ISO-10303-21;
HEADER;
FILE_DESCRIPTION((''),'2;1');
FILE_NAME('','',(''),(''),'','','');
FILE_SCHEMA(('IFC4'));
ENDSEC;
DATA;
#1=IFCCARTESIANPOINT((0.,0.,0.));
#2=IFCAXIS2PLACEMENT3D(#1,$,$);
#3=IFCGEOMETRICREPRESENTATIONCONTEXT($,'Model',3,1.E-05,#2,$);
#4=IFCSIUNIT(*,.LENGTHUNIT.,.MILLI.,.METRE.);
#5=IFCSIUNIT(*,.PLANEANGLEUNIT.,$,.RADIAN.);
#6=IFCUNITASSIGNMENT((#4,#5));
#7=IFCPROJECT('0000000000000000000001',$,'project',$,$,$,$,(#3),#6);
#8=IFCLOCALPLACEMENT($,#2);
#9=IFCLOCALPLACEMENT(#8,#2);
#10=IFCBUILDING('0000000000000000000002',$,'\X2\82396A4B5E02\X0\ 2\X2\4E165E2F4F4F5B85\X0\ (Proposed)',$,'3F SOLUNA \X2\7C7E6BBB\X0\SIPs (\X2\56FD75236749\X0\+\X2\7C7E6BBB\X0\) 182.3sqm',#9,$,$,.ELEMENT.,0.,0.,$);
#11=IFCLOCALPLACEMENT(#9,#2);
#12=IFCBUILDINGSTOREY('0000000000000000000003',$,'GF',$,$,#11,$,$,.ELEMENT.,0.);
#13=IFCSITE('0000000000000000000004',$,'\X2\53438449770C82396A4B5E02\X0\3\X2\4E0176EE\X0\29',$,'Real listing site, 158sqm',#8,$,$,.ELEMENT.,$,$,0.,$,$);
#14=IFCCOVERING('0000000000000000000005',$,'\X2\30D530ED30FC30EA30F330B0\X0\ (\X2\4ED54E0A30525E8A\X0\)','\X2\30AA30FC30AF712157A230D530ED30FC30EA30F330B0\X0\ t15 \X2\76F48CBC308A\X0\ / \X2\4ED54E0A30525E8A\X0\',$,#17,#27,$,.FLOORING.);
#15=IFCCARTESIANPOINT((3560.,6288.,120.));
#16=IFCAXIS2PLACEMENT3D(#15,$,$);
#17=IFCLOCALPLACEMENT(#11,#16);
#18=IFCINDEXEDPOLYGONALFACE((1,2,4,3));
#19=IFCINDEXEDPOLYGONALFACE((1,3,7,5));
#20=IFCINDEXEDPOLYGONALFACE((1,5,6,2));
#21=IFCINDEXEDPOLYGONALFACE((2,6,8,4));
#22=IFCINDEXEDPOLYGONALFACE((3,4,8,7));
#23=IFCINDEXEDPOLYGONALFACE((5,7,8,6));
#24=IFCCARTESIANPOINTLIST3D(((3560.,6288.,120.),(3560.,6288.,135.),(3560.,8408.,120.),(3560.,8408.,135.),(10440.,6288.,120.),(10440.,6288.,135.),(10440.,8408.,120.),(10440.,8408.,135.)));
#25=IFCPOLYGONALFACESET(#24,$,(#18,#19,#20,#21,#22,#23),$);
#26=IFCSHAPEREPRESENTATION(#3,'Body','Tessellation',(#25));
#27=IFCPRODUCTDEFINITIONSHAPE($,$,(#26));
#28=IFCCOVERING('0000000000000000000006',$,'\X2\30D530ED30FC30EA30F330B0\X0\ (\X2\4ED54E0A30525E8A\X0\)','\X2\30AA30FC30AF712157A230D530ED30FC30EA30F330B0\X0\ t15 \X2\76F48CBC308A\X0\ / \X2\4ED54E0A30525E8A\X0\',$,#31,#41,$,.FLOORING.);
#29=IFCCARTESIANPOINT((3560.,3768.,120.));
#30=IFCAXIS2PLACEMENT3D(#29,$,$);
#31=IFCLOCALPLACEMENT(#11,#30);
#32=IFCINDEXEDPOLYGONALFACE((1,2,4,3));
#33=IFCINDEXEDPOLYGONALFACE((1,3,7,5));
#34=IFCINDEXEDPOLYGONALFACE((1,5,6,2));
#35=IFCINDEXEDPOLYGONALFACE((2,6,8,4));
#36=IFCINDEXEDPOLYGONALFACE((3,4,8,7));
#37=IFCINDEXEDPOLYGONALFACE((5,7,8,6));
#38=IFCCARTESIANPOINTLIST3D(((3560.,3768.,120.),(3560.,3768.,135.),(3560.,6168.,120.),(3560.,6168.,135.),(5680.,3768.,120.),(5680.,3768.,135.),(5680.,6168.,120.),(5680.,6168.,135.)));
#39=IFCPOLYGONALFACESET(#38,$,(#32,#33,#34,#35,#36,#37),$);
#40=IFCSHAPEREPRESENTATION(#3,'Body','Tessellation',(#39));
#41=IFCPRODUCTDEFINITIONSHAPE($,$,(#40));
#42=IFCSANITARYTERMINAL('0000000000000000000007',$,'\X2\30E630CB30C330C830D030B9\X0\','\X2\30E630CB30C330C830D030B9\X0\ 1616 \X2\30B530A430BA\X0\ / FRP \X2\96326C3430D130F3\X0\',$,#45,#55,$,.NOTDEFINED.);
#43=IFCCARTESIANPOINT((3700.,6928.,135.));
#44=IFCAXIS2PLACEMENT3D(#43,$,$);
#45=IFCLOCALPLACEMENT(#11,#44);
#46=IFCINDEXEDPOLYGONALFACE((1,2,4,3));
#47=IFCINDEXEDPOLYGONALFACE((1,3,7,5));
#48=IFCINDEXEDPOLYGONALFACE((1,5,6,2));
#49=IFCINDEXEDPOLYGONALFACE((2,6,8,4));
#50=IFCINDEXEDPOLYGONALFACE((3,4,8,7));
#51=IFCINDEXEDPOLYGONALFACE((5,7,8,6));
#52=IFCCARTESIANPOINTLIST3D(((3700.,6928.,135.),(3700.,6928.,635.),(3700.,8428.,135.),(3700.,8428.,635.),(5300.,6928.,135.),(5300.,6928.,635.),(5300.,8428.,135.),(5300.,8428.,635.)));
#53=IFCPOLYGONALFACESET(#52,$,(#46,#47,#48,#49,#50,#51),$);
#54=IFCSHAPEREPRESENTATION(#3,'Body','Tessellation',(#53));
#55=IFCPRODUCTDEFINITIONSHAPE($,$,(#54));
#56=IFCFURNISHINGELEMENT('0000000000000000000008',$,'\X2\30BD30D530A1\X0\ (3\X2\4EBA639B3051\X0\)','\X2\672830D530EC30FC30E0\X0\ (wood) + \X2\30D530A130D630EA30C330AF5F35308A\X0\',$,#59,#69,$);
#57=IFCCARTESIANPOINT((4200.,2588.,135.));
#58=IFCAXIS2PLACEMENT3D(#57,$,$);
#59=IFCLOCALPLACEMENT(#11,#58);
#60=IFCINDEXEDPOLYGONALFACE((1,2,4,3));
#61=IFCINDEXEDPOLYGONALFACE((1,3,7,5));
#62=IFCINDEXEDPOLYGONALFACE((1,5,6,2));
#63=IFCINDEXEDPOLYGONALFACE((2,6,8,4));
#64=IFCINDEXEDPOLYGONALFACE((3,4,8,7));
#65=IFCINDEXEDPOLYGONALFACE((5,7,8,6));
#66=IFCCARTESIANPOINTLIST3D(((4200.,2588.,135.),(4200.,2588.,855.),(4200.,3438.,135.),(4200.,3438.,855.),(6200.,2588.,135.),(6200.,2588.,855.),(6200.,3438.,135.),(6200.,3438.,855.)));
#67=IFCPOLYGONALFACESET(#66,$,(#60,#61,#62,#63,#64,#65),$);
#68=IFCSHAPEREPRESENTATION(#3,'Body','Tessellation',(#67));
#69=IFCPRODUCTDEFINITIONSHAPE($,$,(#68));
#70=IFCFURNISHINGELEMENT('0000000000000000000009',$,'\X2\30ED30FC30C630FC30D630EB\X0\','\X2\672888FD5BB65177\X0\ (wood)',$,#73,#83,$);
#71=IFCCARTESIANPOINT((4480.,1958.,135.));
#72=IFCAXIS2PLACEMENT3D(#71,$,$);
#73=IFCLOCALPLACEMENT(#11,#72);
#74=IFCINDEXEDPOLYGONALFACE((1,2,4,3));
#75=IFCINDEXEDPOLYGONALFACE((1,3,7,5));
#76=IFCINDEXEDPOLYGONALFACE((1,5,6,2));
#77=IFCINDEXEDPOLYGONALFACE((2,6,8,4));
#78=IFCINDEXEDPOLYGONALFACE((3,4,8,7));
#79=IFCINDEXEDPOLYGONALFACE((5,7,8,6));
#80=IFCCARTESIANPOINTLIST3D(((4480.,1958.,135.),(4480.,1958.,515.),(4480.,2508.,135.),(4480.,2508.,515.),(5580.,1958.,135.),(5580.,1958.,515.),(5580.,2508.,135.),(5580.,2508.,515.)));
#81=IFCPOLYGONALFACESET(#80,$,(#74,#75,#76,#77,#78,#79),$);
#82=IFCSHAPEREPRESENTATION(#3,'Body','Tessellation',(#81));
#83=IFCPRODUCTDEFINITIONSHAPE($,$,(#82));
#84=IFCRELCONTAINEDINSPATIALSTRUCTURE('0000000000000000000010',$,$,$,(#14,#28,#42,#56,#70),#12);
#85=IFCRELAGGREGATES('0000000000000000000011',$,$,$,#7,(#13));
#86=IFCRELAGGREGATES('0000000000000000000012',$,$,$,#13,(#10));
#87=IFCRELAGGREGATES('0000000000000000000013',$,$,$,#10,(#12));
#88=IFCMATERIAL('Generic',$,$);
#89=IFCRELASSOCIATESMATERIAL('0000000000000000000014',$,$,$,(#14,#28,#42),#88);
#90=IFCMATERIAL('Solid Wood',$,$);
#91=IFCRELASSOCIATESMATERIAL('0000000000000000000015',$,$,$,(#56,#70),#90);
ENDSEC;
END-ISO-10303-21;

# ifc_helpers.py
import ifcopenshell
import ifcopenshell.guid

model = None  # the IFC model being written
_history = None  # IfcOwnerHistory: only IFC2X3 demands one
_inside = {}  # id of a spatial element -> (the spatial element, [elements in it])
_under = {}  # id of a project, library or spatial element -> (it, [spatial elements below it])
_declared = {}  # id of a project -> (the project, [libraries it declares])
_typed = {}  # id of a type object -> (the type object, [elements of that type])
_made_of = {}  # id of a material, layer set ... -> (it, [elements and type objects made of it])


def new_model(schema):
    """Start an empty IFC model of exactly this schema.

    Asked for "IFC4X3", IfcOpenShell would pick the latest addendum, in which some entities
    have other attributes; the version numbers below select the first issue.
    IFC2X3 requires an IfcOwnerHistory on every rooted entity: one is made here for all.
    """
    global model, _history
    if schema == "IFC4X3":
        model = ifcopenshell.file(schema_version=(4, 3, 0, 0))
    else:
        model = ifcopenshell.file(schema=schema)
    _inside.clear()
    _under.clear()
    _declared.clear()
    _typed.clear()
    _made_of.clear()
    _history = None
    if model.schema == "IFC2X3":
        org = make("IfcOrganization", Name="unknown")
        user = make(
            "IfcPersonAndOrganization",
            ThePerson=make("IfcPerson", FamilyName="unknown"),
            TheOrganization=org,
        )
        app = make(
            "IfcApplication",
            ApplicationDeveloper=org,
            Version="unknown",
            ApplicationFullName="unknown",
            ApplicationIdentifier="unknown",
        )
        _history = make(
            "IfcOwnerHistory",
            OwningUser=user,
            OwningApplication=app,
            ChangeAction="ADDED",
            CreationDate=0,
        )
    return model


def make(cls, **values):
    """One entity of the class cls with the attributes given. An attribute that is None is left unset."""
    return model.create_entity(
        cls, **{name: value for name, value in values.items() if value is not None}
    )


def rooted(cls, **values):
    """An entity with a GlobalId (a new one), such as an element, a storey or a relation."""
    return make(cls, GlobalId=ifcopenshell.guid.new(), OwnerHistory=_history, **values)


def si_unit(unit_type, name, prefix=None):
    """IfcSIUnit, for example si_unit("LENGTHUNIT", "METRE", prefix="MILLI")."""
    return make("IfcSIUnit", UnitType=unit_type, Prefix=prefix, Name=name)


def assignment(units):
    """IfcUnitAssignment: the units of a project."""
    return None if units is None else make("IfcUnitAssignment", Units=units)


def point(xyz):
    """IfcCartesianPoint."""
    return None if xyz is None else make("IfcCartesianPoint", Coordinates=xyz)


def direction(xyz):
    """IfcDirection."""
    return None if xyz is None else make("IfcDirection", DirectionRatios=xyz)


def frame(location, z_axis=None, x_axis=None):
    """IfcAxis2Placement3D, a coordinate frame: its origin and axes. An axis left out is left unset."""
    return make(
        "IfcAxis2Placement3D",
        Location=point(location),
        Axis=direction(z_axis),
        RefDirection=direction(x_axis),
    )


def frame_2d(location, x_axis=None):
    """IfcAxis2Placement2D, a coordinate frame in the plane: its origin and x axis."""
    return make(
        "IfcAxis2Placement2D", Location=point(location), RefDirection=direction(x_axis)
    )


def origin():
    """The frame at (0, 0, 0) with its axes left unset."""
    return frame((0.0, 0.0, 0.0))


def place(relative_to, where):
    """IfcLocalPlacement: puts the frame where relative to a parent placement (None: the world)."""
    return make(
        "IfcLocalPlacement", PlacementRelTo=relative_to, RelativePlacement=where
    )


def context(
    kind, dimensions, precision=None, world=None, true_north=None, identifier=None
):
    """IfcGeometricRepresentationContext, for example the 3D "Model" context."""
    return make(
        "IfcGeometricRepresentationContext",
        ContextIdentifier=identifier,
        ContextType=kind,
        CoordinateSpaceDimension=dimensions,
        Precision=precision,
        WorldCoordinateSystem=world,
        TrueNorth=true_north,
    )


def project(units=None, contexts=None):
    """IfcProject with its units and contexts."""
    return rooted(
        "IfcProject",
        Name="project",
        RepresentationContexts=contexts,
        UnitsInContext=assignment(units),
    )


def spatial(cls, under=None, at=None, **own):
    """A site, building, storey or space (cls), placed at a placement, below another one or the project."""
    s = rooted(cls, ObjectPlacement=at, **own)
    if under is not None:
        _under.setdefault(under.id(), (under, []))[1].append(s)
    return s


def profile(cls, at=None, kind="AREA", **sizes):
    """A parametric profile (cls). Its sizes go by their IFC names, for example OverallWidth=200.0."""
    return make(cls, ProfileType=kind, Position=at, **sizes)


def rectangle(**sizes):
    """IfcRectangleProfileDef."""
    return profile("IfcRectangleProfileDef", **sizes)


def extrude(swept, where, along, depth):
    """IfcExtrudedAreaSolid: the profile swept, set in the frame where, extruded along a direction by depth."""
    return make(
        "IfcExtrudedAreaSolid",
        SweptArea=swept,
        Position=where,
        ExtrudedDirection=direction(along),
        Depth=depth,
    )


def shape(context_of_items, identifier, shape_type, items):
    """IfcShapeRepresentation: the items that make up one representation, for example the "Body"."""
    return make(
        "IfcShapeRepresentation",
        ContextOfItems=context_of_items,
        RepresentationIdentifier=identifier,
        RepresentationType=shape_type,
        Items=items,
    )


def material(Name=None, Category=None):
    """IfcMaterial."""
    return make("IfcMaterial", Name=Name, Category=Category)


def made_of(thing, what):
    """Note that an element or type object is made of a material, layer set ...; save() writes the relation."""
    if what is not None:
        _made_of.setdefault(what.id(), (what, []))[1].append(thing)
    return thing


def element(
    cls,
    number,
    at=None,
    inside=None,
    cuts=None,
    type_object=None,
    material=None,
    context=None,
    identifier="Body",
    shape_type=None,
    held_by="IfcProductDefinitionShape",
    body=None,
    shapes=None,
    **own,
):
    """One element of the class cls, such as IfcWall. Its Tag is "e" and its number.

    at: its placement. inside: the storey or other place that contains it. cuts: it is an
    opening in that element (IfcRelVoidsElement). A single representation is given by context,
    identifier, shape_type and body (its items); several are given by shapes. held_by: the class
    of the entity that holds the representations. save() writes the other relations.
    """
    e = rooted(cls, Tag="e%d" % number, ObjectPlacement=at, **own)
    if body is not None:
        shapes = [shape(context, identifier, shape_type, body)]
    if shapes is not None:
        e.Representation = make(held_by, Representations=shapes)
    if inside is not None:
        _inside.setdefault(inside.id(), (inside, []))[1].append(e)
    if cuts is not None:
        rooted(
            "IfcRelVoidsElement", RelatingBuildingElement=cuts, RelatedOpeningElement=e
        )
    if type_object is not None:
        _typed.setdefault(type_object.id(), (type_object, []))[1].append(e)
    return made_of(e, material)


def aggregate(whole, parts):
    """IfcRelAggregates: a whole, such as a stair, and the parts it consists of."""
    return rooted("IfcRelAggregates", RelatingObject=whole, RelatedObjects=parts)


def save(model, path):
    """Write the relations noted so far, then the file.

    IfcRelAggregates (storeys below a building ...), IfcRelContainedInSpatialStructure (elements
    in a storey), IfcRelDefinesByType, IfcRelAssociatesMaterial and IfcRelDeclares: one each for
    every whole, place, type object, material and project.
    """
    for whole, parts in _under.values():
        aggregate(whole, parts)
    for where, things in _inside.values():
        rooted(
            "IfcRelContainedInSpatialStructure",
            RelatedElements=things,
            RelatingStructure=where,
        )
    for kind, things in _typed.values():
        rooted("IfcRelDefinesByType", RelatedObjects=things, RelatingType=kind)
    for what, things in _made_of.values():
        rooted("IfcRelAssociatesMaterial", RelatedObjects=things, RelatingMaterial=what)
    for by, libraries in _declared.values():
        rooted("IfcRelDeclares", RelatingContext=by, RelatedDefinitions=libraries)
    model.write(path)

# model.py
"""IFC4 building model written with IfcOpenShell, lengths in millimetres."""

from ifc_helpers import new_model, si_unit, frame, frame_2d, origin, place, context, project, spatial, rectangle, extrude, material, element, save


model = new_model("IFC4")

# Units and contexts
model_context = context("Model", 3, precision=1e-05, world=origin())
ifc_project = project(units=[si_unit("LENGTHUNIT", "METRE", prefix="MILLI"), si_unit("PLANEANGLEUNIT", "RADIAN")], contexts=[model_context])

# Site, building, storey
site_placement = place(None, origin())
site = spatial("IfcSite", under=ifc_project, at=site_placement, Name="千葉県船橋市3丁目29", ObjectType="Real listing site, 158sqm", CompositionType="ELEMENT", RefElevation=0.0)
building_placement = place(site_placement, origin())
building = spatial("IfcBuilding", under=site, at=building_placement, Name="船橋市 2世帯住宅 (Proposed)", ObjectType="3F SOLUNA 籾殻SIPs (国産杉+籾殻) 182.3sqm", CompositionType="ELEMENT", ElevationOfRefHeight=0.0, ElevationOfTerrain=0.0)
storey_placement = place(building_placement, origin())
storey = spatial("IfcBuildingStorey", under=building, at=storey_placement, Name="GF", CompositionType="ELEMENT", Elevation=0.0)

# Shared definitions
ifc_material_1 = material(Name="Solid Wood")

# Coverings
ifc_material_2 = material(Name="Generic")
covering_1_placement = place(storey_placement, frame((3560.0, 6288.0, 120.0)))
element("IfcCovering", 1, at=covering_1_placement, inside=storey, material=ifc_material_2, Name="フローリング (仕上げ床)", Description="オーク無垢フローリング t15 直貼り / 仕上げ床", PredefinedType="FLOORING", context=model_context, shape_type="SweptSolid", body=[
    extrude(rectangle(XDim=6880.0, YDim=2120.0, at=frame_2d((3440.0, 1060.0))), frame((3560.0, 6288.0, 120.0)), (0.0, 0.0, 1.0), 15.0),
])
covering_2_placement = place(storey_placement, frame((3560.0, 3768.0, 120.0)))
element("IfcCovering", 2, at=covering_2_placement, inside=storey, material=ifc_material_2, Name="フローリング (仕上げ床)", Description="オーク無垢フローリング t15 直貼り / 仕上げ床", PredefinedType="FLOORING", context=model_context, shape_type="SweptSolid", body=[
    extrude(rectangle(XDim=2120.0, YDim=2400.0, at=frame_2d((1060.0, 1200.0))), frame((3560.0, 3768.0, 120.0)), (0.0, 0.0, 1.0), 15.0),
])

# Sanitary terminal
sanitary_terminal_placement = place(storey_placement, frame((3700.0, 6928.0, 135.0)))
element("IfcSanitaryTerminal", 3, at=sanitary_terminal_placement, inside=storey, material=ifc_material_2, Name="ユニットバス", Description="ユニットバス 1616 サイズ / FRP 防水パン", PredefinedType="NOTDEFINED", context=model_context, shape_type="SweptSolid", body=[
    extrude(rectangle(XDim=1600.0, YDim=1500.0, at=frame_2d((800.0, 750.0))), frame((3700.0, 6928.0, 135.0)), (0.0, 0.0, 1.0), 500.0),
])

# Furnishing elements
furnishing_1_placement = place(storey_placement, frame((4200.0, 2588.0, 135.0)))
element("IfcFurnishingElement", 4, at=furnishing_1_placement, inside=storey, material=ifc_material_1, Name="ソファ (3人掛け)", Description="木フレーム (wood) + ファブリック張り", context=model_context, shape_type="SweptSolid", body=[
    extrude(rectangle(XDim=2000.0, YDim=850.0, at=frame_2d((1000.0, 425.0))), frame((4200.0, 2588.0, 135.0)), (0.0, 0.0, 1.0), 720.0),
])
furnishing_2_placement = place(storey_placement, frame((4480.0, 1958.0, 135.0)))
element("IfcFurnishingElement", 5, at=furnishing_2_placement, inside=storey, material=ifc_material_1, Name="ローテーブル", Description="木製家具 (wood)", context=model_context, shape_type="SweptSolid", body=[
    extrude(rectangle(XDim=1100.0, YDim=550.0, at=frame_2d((550.0, 275.0))), frame((4480.0, 1958.0, 135.0)), (0.0, 0.0, 1.0), 380.0),
])

save(model, "model.ifc")
